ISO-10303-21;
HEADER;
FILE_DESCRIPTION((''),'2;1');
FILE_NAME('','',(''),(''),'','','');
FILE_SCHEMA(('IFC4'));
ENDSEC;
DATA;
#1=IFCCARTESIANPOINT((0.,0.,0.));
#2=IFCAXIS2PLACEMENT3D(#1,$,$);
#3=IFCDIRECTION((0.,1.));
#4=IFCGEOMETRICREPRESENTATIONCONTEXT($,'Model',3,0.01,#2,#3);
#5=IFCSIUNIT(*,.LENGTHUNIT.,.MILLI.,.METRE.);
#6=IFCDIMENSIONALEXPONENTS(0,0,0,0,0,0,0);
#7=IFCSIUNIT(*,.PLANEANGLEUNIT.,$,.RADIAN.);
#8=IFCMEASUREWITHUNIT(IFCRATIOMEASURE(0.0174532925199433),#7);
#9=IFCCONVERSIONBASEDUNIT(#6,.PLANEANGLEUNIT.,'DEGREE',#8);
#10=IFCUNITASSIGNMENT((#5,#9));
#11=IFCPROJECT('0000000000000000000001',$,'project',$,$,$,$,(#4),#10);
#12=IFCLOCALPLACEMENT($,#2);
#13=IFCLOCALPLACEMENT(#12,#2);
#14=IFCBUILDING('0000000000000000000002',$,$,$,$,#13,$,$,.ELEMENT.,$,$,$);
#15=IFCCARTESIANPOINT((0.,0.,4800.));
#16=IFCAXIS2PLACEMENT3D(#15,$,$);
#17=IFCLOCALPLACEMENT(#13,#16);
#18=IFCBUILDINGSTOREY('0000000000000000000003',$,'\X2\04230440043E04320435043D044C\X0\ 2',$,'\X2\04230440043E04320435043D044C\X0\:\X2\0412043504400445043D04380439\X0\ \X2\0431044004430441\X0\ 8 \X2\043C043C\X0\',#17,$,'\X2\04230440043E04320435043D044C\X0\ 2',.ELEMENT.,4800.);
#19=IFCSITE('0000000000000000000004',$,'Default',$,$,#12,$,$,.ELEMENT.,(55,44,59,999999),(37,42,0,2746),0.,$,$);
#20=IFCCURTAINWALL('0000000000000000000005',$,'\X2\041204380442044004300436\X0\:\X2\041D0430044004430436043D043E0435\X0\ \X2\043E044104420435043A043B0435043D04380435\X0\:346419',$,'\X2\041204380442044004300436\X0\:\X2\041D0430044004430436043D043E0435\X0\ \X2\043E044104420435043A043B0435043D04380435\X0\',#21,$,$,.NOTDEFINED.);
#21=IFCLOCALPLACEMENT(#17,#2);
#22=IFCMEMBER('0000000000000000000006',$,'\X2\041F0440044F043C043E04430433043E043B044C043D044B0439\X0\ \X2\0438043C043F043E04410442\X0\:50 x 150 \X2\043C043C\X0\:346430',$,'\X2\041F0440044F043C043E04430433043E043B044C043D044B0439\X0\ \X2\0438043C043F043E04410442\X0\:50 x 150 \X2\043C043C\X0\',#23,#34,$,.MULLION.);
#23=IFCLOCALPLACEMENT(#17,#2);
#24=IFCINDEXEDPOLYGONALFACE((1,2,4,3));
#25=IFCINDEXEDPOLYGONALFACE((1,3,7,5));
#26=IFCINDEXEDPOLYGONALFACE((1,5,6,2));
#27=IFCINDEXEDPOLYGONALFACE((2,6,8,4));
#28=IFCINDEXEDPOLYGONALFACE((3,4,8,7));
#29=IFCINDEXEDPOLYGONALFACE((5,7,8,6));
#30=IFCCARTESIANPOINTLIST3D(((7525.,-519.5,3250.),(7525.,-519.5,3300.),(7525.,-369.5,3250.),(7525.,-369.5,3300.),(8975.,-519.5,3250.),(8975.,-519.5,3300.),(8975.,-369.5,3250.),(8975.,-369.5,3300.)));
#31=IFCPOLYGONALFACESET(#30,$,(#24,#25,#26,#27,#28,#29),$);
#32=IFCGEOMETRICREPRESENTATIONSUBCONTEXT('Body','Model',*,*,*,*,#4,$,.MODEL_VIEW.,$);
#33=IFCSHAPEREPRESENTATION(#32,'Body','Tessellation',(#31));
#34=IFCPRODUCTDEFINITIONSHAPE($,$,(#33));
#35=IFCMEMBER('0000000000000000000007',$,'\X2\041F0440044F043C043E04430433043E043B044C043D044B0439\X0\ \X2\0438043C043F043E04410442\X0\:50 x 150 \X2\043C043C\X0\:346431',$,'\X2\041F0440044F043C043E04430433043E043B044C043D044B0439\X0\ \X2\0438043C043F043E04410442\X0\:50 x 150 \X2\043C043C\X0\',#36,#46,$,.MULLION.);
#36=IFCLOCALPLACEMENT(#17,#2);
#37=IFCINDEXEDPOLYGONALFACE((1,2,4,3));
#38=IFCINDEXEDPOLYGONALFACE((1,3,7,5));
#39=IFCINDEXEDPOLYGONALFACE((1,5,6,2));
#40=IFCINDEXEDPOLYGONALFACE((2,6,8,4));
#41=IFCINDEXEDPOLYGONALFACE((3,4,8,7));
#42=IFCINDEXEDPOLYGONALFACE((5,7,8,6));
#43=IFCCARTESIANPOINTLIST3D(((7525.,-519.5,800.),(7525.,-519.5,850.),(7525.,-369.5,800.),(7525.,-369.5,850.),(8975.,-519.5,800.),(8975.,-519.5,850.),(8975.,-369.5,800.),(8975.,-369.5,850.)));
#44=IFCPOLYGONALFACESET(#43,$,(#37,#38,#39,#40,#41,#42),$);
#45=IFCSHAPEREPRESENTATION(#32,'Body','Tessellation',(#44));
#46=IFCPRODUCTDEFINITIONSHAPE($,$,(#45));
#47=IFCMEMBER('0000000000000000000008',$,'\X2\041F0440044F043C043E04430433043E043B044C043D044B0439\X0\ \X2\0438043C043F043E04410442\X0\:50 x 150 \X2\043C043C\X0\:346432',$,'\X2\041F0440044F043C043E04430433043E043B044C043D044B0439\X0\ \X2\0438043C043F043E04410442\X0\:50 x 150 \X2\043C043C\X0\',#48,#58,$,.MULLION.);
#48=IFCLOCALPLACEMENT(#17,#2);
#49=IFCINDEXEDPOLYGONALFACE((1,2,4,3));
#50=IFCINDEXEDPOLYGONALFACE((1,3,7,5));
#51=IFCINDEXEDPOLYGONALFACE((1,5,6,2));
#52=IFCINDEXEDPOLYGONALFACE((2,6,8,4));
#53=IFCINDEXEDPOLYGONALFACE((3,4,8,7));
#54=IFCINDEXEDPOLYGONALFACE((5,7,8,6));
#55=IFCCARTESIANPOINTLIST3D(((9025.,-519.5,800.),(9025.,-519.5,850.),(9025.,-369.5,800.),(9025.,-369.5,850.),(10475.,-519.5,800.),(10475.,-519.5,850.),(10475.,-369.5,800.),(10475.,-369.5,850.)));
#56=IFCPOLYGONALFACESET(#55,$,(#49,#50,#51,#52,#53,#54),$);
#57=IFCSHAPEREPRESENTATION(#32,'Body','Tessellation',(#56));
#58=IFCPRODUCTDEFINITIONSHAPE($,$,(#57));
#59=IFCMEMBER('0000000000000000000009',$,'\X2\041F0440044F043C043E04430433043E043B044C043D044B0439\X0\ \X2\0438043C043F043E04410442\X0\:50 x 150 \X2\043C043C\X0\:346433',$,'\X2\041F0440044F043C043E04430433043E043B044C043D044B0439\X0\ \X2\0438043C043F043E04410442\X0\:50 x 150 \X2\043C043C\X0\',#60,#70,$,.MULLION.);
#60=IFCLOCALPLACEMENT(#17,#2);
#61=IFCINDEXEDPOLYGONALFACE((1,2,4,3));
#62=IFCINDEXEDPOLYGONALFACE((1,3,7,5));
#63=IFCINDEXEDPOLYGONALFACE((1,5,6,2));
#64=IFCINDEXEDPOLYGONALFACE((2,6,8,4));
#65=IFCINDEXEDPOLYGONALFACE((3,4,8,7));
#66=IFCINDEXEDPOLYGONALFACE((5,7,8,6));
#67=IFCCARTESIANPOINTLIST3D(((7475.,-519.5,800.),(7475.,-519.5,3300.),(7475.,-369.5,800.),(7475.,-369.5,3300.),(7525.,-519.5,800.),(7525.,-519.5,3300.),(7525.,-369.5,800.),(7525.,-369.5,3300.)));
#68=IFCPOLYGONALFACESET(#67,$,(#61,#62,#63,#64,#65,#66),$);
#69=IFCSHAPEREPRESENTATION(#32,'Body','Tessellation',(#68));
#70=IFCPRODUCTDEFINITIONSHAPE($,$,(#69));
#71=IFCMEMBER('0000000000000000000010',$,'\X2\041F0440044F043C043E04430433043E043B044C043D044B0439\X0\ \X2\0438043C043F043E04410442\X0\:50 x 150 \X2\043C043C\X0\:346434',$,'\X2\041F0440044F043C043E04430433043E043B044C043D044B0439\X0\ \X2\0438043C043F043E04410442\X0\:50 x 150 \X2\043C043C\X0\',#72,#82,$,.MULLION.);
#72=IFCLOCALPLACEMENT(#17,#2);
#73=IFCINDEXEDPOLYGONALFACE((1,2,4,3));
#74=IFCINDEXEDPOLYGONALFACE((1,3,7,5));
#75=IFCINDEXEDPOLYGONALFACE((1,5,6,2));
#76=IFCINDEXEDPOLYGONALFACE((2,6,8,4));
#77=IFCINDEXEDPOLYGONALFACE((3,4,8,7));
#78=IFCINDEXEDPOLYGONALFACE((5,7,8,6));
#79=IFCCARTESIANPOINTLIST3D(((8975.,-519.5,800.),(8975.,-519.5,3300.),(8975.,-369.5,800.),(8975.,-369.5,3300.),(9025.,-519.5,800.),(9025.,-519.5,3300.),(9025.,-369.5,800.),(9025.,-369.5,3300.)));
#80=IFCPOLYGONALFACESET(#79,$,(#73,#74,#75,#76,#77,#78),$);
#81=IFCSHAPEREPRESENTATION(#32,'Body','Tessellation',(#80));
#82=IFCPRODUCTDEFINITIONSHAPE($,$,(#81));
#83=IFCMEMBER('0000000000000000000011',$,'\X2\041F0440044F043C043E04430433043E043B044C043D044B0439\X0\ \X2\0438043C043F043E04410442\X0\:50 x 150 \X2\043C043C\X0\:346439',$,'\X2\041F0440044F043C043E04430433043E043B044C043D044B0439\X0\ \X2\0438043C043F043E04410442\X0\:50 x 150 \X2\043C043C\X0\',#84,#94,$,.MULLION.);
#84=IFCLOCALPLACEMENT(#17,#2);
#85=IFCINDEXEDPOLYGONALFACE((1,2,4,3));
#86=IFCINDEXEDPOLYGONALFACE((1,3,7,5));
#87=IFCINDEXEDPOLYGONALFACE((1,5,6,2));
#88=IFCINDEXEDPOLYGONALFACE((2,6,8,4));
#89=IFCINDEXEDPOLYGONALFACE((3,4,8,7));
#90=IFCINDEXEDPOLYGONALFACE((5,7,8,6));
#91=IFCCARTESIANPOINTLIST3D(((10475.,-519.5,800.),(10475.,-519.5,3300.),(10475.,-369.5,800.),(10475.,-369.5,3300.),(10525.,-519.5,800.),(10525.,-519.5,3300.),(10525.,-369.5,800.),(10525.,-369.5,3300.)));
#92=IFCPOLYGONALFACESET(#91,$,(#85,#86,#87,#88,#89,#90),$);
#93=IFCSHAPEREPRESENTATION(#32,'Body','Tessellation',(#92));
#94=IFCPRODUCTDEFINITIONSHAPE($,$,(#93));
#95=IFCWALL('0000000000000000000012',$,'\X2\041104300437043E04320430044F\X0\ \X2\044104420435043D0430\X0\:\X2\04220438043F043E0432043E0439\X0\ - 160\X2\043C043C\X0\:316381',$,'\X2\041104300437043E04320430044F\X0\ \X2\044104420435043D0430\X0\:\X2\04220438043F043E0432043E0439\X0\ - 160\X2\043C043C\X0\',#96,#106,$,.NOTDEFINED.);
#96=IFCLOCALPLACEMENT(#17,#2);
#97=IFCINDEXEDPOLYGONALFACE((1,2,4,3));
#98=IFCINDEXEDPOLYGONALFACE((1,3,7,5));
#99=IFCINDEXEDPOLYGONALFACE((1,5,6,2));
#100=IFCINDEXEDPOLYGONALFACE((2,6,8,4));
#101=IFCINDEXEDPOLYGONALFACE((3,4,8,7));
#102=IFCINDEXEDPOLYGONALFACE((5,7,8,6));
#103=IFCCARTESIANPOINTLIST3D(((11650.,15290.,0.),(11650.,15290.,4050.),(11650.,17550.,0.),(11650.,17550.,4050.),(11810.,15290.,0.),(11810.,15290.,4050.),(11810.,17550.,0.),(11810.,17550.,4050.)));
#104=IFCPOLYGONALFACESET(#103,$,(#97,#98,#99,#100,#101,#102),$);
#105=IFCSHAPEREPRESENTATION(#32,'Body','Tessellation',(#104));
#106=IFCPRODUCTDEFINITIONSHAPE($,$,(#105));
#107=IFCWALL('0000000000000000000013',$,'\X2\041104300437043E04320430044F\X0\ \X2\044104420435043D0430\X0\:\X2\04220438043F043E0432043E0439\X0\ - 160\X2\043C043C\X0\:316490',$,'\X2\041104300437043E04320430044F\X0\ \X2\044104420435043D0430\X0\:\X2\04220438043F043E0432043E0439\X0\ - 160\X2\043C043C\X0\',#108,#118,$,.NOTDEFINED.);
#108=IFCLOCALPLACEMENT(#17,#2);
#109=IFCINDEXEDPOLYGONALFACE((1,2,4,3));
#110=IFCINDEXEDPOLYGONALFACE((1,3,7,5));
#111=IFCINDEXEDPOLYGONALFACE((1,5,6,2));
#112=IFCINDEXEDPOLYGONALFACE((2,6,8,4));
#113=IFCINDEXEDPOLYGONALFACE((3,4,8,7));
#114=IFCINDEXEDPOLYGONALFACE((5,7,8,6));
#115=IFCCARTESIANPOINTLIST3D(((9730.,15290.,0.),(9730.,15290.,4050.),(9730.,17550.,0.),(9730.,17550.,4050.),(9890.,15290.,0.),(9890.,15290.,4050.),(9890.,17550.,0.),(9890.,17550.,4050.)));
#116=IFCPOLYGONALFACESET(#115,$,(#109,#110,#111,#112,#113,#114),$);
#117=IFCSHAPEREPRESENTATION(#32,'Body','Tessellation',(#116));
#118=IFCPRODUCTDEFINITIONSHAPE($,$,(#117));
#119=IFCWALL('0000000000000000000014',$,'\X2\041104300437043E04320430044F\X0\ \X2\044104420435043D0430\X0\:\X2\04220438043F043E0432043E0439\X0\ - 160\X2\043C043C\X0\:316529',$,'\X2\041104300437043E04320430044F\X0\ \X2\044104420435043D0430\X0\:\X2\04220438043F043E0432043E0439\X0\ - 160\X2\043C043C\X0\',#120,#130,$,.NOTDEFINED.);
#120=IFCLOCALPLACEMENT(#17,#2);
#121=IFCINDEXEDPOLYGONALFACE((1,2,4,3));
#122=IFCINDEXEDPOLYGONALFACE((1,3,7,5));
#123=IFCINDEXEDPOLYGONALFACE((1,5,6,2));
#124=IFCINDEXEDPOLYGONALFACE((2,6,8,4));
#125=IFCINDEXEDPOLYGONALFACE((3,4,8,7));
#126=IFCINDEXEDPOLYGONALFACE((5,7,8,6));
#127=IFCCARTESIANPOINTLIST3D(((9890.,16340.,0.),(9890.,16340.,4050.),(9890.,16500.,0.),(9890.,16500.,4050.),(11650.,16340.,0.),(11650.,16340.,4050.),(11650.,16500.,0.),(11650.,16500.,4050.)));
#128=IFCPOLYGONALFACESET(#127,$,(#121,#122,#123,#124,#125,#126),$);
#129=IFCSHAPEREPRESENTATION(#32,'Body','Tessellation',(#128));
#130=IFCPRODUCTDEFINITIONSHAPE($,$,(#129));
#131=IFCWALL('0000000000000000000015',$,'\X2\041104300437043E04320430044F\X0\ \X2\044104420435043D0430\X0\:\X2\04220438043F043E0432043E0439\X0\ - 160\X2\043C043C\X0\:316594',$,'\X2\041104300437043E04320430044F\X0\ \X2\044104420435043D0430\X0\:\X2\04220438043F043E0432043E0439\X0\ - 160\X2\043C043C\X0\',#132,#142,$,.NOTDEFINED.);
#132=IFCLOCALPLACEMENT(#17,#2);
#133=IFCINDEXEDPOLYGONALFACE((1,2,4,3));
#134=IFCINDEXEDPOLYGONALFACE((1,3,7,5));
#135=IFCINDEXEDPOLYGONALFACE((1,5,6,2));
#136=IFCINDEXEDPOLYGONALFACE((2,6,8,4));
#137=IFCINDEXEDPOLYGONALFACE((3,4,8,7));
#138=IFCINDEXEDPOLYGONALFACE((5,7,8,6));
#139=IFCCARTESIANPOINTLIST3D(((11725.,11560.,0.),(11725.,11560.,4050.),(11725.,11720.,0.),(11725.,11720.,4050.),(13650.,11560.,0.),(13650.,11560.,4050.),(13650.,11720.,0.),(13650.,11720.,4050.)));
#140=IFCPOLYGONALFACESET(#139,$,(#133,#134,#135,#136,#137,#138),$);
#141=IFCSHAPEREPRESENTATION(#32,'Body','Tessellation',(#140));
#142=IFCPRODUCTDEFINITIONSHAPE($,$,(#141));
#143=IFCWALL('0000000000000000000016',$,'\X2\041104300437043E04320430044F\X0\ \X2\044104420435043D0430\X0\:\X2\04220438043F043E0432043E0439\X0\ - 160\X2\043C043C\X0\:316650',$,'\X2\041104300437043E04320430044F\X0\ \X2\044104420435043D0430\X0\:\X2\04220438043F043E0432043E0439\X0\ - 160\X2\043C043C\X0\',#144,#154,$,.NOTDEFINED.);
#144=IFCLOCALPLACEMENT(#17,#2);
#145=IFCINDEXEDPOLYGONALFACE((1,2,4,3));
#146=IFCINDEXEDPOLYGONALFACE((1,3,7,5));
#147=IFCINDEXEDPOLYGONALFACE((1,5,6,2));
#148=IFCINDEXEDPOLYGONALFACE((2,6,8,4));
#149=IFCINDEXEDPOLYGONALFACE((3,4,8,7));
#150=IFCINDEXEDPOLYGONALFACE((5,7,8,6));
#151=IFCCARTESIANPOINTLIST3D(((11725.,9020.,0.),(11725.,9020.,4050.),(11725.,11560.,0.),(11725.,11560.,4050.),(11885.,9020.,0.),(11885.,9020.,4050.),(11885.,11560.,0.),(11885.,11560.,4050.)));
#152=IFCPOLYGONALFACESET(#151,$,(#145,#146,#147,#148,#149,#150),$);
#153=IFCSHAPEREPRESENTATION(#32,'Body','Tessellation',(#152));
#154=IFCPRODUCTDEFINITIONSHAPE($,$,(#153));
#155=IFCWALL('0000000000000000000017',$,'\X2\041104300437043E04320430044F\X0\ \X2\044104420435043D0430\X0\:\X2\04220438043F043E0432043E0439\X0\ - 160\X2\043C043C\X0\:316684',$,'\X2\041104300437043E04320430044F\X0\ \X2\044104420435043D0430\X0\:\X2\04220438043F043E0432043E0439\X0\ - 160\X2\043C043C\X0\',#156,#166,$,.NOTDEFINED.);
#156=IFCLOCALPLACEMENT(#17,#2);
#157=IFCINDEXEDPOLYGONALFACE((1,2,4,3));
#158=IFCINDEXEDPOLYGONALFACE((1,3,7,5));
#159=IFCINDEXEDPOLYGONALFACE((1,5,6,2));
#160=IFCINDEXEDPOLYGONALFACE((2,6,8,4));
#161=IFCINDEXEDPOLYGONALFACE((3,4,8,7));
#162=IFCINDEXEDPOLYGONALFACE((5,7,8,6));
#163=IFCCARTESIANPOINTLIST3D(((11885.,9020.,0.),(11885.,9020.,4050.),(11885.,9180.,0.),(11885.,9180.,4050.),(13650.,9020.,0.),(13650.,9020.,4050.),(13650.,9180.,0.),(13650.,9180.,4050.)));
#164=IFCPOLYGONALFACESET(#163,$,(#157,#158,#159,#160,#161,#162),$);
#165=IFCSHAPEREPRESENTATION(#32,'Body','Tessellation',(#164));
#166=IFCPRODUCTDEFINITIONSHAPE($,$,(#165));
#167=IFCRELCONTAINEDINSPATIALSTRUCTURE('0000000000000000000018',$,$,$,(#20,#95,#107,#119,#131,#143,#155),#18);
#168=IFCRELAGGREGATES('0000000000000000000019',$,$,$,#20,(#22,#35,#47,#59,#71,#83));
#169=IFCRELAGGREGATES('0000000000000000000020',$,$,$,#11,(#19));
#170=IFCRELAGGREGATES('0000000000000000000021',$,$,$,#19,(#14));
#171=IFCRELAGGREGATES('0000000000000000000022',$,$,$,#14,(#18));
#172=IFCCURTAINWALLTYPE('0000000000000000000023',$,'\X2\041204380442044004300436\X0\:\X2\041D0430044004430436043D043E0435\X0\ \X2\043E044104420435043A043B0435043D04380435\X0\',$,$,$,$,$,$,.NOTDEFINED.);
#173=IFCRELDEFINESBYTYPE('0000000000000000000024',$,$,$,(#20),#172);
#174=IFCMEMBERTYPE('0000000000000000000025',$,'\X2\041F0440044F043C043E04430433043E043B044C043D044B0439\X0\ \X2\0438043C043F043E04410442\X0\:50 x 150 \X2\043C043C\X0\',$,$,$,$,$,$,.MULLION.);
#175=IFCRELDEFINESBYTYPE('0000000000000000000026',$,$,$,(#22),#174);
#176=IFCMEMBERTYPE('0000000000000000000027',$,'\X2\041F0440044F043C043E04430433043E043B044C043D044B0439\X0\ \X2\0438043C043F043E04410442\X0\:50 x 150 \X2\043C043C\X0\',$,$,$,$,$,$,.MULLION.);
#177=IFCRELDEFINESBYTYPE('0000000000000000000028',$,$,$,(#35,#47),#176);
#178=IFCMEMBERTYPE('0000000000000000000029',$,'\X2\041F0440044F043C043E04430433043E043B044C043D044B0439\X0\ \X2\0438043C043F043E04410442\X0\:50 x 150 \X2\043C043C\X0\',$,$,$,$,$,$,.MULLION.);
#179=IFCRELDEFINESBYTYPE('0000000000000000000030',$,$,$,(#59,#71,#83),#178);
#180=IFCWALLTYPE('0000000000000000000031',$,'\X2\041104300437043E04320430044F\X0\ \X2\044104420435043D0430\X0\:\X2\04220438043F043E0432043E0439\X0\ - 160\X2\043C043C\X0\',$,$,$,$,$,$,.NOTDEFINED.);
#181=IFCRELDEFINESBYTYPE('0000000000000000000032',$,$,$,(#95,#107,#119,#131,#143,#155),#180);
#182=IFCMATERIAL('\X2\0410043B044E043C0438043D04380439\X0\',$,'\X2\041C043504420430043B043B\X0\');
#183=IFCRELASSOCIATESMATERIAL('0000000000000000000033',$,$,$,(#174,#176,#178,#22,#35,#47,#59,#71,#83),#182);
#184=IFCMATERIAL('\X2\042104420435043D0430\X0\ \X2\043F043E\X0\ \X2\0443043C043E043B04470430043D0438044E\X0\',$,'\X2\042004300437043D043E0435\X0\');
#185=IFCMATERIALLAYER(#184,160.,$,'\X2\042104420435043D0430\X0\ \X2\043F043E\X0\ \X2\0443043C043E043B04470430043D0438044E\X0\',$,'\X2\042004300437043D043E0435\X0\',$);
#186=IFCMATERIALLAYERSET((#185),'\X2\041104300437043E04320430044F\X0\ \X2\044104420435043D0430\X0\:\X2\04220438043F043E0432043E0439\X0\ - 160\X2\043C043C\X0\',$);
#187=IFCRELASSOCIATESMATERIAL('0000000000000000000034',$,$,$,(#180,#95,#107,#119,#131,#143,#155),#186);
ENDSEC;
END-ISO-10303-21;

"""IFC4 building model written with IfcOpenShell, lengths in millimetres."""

from ifc_helpers import new_model, entity, si_unit, converted_unit, direction, frame, frame_2d, origin, origin_2d_with_axis, place, context, subcontext, project, spatial, rectangle, extrude, source, transform, mapped, material, layer, layer_set, layer_usage, material_profile, profile_set, profile_usage, type_object, type_shapes, element, aggregate, save


model = new_model("IFC4")

# Units and contexts
model_context = context("Model", 3, precision=0.01, world=origin(), true_north=direction((0.0, 1.0)))
body_context = subcontext(model_context, "Body", "Model", "MODEL_VIEW")
ifc_project = project(units=[si_unit("LENGTHUNIT", "METRE", prefix="MILLI"), converted_unit("PLANEANGLEUNIT", "DEGREE", entity("IfcRatioMeasure", 0.0174532925199433), si_unit("PLANEANGLEUNIT", "RADIAN"), dimensions=[0, 0, 0, 0, 0, 0, 0])], contexts=[model_context])

# Site, building, storey
site_placement = place(None, origin())
site = spatial("IfcSite", under=ifc_project, at=site_placement, Name="Default", CompositionType="ELEMENT", RefLatitude=(55, 44, 59, 999999), RefLongitude=(37, 42, 0, 2746), RefElevation=0.0)
building_placement = place(site_placement, origin())
building = spatial("IfcBuilding", under=site, at=building_placement, CompositionType="ELEMENT")
storey_placement = place(building_placement, frame((0.0, 0.0, 4800.0)))
storey = spatial("IfcBuildingStorey", under=building, at=storey_placement, Name="Уровень 2", ObjectType="Уровень:Верхний брус 8 мм", LongName="Уровень 2", CompositionType="ELEMENT", Elevation=4800.0)

# Curtain wall, members
curtain_wall_type = type_object("IfcCurtainWallType", Name="Витраж:Наружное остекление", PredefinedType="NOTDEFINED")
curtain_wall_1_placement = place(storey_placement, frame((0.0, 0.0, -4800.0)))
curtain_wall_1 = element("IfcCurtainWall", 1, at=curtain_wall_1_placement, inside=storey, type_object=curtain_wall_type, Name="Витраж:Наружное остекление:346419", ObjectType="Витраж:Наружное остекление", PredefinedType="NOTDEFINED")
ifc_material_1 = material(Name="Алюминий", Category="Металл")
ifc_material_profile = material_profile(ifc_material_1, rectangle(XDim=150.0, YDim=50.0, at=origin_2d_with_axis()), Name="50 x 150 мм")
ifc_profile_set = profile_set([ifc_material_profile], Name="50 x 150 мм")
ifc_profile_usage_1 = profile_usage(ifc_profile_set)
member_type_1 = type_object("IfcMemberType", Name="Прямоугольный импост:50 x 150 мм", PredefinedType="MULLION", material=ifc_profile_set)
shared_shape_1 = source(origin(), body_context, "Body", "SweptSolid", [
    extrude(rectangle(XDim=150.0, YDim=50.0, at=origin_2d_with_axis()), frame((-25.0, 0.0, -1450.0), z_axis=(0.0, 0.0, 1.0), x_axis=(0.0, -1.0, 0.0)), (0.0, 0.0, 1.0), 1450.0),
])
type_shapes(member_type_1, [shared_shape_1])
member_1_placement = place(storey_placement, frame((8975.0, -444.5, 3300.0), z_axis=(1.0, 0.0, 0.0), x_axis=(0.0, 0.0, 1.0)))
member_1 = element("IfcMember", 2, at=member_1_placement, type_object=member_type_1, material=ifc_profile_usage_1, Name="Прямоугольный импост:50 x 150 мм:346430", ObjectType="Прямоугольный импост:50 x 150 мм", PredefinedType="MULLION", context=body_context, shape_type="MappedRepresentation", body=[
    mapped(shared_shape_1, transform((0.0, 0.0, 0.0), scale=1.0)),
])
ifc_profile_usage_2 = profile_usage(ifc_profile_set)
member_type_2 = type_object("IfcMemberType", Name="Прямоугольный импост:50 x 150 мм", PredefinedType="MULLION", material=ifc_profile_set)
shared_shape_2 = source(origin(), body_context, "Body", "SweptSolid", [
    extrude(rectangle(XDim=150.0, YDim=50.0, at=origin_2d_with_axis()), frame((-25.0, 0.0, -1450.0), z_axis=(0.0, 0.0, 1.0), x_axis=(0.0, -1.0, 0.0)), (0.0, 0.0, 1.0), 1450.0),
])
type_shapes(member_type_2, [shared_shape_2])
member_2_placement = place(storey_placement, frame((7525.0, -444.5, 800.0), z_axis=(-1.0, 0.0, 0.0), x_axis=(0.0, 0.0, -1.0)))
member_2 = element("IfcMember", 3, at=member_2_placement, type_object=member_type_2, material=ifc_profile_usage_2, Name="Прямоугольный импост:50 x 150 мм:346431", ObjectType="Прямоугольный импост:50 x 150 мм", PredefinedType="MULLION", context=body_context, shape_type="MappedRepresentation", body=[
    mapped(shared_shape_2, transform((0.0, 0.0, 0.0), scale=1.0)),
])
ifc_profile_usage_3 = profile_usage(ifc_profile_set)
member_3_placement = place(storey_placement, frame((9025.0, -444.5, 800.0), z_axis=(-1.0, 0.0, 0.0), x_axis=(0.0, 0.0, -1.0)))
member_3 = element("IfcMember", 4, at=member_3_placement, type_object=member_type_2, material=ifc_profile_usage_3, Name="Прямоугольный импост:50 x 150 мм:346432", ObjectType="Прямоугольный импост:50 x 150 мм", PredefinedType="MULLION", context=body_context, shape_type="MappedRepresentation", body=[
    mapped(shared_shape_2, transform((0.0, 0.0, 0.0), scale=1.0)),
])
ifc_profile_usage_4 = profile_usage(ifc_profile_set)
member_type_3 = type_object("IfcMemberType", Name="Прямоугольный импост:50 x 150 мм", PredefinedType="MULLION", material=ifc_profile_set)
shared_shape_3 = source(origin(), body_context, "Body", "SweptSolid", [
    extrude(rectangle(XDim=150.0, YDim=50.0, at=origin_2d_with_axis()), frame((0.0, 0.0, -2500.0), z_axis=(0.0, 0.0, 1.0), x_axis=(0.0, -1.0, 0.0)), (0.0, 0.0, 1.0), 2500.0),
])
type_shapes(member_type_3, [shared_shape_3])
member_4_placement = place(storey_placement, frame((7500.0, -444.5, 800.0), z_axis=(0.0, 0.0, -1.0), x_axis=(1.0, 0.0, 0.0)))
member_4 = element("IfcMember", 5, at=member_4_placement, type_object=member_type_3, material=ifc_profile_usage_4, Name="Прямоугольный импост:50 x 150 мм:346433", ObjectType="Прямоугольный импост:50 x 150 мм", PredefinedType="MULLION", context=body_context, shape_type="MappedRepresentation", body=[
    mapped(shared_shape_3, transform((0.0, 0.0, 0.0), scale=1.0)),
])
ifc_profile_usage_5 = profile_usage(ifc_profile_set)
member_5_placement = place(storey_placement, frame((9000.0, -444.5, 800.0), z_axis=(0.0, 0.0, -1.0), x_axis=(1.0, 0.0, 0.0)))
member_5 = element("IfcMember", 6, at=member_5_placement, type_object=member_type_3, material=ifc_profile_usage_5, Name="Прямоугольный импост:50 x 150 мм:346434", ObjectType="Прямоугольный импост:50 x 150 мм", PredefinedType="MULLION", context=body_context, shape_type="MappedRepresentation", body=[
    mapped(shared_shape_3, transform((0.0, 0.0, 0.0), scale=1.0)),
])
ifc_profile_usage_6 = profile_usage(ifc_profile_set)
member_6_placement = place(storey_placement, frame((10500.0, -444.5, 800.0), z_axis=(0.0, 0.0, -1.0), x_axis=(1.0, 0.0, 0.0)))
member_6 = element("IfcMember", 7, at=member_6_placement, type_object=member_type_3, material=ifc_profile_usage_6, Name="Прямоугольный импост:50 x 150 мм:346439", ObjectType="Прямоугольный импост:50 x 150 мм", PredefinedType="MULLION", context=body_context, shape_type="MappedRepresentation", body=[
    mapped(shared_shape_3, transform((0.0, 0.0, 0.0), scale=1.0)),
])

aggregate(curtain_wall_1, [member_1, member_2, member_3, member_4, member_5, member_6])

# Shared definitions
ifc_material_2 = material(Name="Стена по умолчанию", Category="Разное")

# Walls
ifc_layer_1 = layer(ifc_material_2, 160.0, Name="Стена по умолчанию", Category="Разное")
ifc_layer_set_1 = layer_set([ifc_layer_1], Name="Базовая стена:Типовой - 160мм")
ifc_layer_usage_1 = layer_usage(ifc_layer_set_1, "AXIS2", "NEGATIVE", 80.0)
wall_type_1 = type_object("IfcWallType", Name="Базовая стена:Типовой - 160мм", PredefinedType="NOTDEFINED", material=ifc_layer_set_1)
wall_1_placement = place(storey_placement, frame((11730.0, 17550.0, 0.0), z_axis=(0.0, 0.0, 1.0), x_axis=(0.0, -1.0, 0.0)))
element("IfcWall", 8, at=wall_1_placement, inside=storey, type_object=wall_type_1, material=ifc_layer_usage_1, Name="Базовая стена:Типовой - 160мм:316381", ObjectType="Базовая стена:Типовой - 160мм", PredefinedType="NOTDEFINED", context=body_context, shape_type="SweptSolid", body=[
    extrude(rectangle(XDim=2260.0, YDim=160.0, at=frame_2d((1130.0, 0.0), x_axis=(-1.0, 0.0))), origin(), (0.0, 0.0, 1.0), 4050.0),
])
ifc_layer_usage_2 = layer_usage(ifc_layer_set_1, "AXIS2", "NEGATIVE", 80.0)
wall_2_placement = place(storey_placement, frame((9810.0, 17550.0, 0.0), z_axis=(0.0, 0.0, 1.0), x_axis=(0.0, -1.0, 0.0)))
element("IfcWall", 9, at=wall_2_placement, inside=storey, type_object=wall_type_1, material=ifc_layer_usage_2, Name="Базовая стена:Типовой - 160мм:316490", ObjectType="Базовая стена:Типовой - 160мм", PredefinedType="NOTDEFINED", context=body_context, shape_type="SweptSolid", body=[
    extrude(rectangle(XDim=2260.0, YDim=160.0, at=frame_2d((1130.0, 0.0), x_axis=(-1.0, 0.0))), origin(), (0.0, 0.0, 1.0), 4050.0),
])
ifc_layer_usage_3 = layer_usage(ifc_layer_set_1, "AXIS2", "NEGATIVE", 80.0)
wall_3_placement = place(storey_placement, frame((9890.0, 16420.0, 0.0)))
element("IfcWall", 10, at=wall_3_placement, inside=storey, type_object=wall_type_1, material=ifc_layer_usage_3, Name="Базовая стена:Типовой - 160мм:316529", ObjectType="Базовая стена:Типовой - 160мм", PredefinedType="NOTDEFINED", context=body_context, shape_type="SweptSolid", body=[
    extrude(rectangle(XDim=1760.0, YDim=160.0, at=frame_2d((880.0, 0.0), x_axis=(-1.0, 0.0))), origin(), (0.0, 0.0, 1.0), 4050.0),
])
ifc_layer_usage_4 = layer_usage(ifc_layer_set_1, "AXIS2", "NEGATIVE", 80.0)
wall_4_placement = place(storey_placement, frame((13650.0, 11640.0, 0.0), z_axis=(0.0, 0.0, 1.0), x_axis=(-1.0, 0.0, 0.0)))
element("IfcWall", 11, at=wall_4_placement, inside=storey, type_object=wall_type_1, material=ifc_layer_usage_4, Name="Базовая стена:Типовой - 160мм:316594", ObjectType="Базовая стена:Типовой - 160мм", PredefinedType="NOTDEFINED", context=body_context, shape_type="SweptSolid", body=[
    extrude(rectangle(XDim=1925.0, YDim=160.0, at=frame_2d((962.5, 0.0), x_axis=(-1.0, 0.0))), origin(), (0.0, 0.0, 1.0), 4050.0),
])
ifc_layer_usage_5 = layer_usage(ifc_layer_set_1, "AXIS2", "NEGATIVE", 80.0)
wall_5_placement = place(storey_placement, frame((11805.0, 11560.0, 0.0), z_axis=(0.0, 0.0, 1.0), x_axis=(0.0, -1.0, 0.0)))
element("IfcWall", 12, at=wall_5_placement, inside=storey, type_object=wall_type_1, material=ifc_layer_usage_5, Name="Базовая стена:Типовой - 160мм:316650", ObjectType="Базовая стена:Типовой - 160мм", PredefinedType="NOTDEFINED", context=body_context, shape_type="SweptSolid", body=[
    extrude(rectangle(XDim=2540.0, YDim=160.0, at=frame_2d((1270.0, 0.0), x_axis=(-1.0, 0.0))), origin(), (0.0, 0.0, 1.0), 4050.0),
])
ifc_layer_usage_6 = layer_usage(ifc_layer_set_1, "AXIS2", "NEGATIVE", 80.0)
wall_6_placement = place(storey_placement, frame((11885.0, 9100.0, 0.0)))
element("IfcWall", 13, at=wall_6_placement, inside=storey, type_object=wall_type_1, material=ifc_layer_usage_6, Name="Базовая стена:Типовой - 160мм:316684", ObjectType="Базовая стена:Типовой - 160мм", PredefinedType="NOTDEFINED", context=body_context, shape_type="SweptSolid", body=[
    extrude(rectangle(XDim=1765.0, YDim=160.0, at=frame_2d((882.5, 0.0), x_axis=(-1.0, 0.0))), origin(), (0.0, 0.0, 1.0), 4050.0),
])

save(model, "model.ifc")
